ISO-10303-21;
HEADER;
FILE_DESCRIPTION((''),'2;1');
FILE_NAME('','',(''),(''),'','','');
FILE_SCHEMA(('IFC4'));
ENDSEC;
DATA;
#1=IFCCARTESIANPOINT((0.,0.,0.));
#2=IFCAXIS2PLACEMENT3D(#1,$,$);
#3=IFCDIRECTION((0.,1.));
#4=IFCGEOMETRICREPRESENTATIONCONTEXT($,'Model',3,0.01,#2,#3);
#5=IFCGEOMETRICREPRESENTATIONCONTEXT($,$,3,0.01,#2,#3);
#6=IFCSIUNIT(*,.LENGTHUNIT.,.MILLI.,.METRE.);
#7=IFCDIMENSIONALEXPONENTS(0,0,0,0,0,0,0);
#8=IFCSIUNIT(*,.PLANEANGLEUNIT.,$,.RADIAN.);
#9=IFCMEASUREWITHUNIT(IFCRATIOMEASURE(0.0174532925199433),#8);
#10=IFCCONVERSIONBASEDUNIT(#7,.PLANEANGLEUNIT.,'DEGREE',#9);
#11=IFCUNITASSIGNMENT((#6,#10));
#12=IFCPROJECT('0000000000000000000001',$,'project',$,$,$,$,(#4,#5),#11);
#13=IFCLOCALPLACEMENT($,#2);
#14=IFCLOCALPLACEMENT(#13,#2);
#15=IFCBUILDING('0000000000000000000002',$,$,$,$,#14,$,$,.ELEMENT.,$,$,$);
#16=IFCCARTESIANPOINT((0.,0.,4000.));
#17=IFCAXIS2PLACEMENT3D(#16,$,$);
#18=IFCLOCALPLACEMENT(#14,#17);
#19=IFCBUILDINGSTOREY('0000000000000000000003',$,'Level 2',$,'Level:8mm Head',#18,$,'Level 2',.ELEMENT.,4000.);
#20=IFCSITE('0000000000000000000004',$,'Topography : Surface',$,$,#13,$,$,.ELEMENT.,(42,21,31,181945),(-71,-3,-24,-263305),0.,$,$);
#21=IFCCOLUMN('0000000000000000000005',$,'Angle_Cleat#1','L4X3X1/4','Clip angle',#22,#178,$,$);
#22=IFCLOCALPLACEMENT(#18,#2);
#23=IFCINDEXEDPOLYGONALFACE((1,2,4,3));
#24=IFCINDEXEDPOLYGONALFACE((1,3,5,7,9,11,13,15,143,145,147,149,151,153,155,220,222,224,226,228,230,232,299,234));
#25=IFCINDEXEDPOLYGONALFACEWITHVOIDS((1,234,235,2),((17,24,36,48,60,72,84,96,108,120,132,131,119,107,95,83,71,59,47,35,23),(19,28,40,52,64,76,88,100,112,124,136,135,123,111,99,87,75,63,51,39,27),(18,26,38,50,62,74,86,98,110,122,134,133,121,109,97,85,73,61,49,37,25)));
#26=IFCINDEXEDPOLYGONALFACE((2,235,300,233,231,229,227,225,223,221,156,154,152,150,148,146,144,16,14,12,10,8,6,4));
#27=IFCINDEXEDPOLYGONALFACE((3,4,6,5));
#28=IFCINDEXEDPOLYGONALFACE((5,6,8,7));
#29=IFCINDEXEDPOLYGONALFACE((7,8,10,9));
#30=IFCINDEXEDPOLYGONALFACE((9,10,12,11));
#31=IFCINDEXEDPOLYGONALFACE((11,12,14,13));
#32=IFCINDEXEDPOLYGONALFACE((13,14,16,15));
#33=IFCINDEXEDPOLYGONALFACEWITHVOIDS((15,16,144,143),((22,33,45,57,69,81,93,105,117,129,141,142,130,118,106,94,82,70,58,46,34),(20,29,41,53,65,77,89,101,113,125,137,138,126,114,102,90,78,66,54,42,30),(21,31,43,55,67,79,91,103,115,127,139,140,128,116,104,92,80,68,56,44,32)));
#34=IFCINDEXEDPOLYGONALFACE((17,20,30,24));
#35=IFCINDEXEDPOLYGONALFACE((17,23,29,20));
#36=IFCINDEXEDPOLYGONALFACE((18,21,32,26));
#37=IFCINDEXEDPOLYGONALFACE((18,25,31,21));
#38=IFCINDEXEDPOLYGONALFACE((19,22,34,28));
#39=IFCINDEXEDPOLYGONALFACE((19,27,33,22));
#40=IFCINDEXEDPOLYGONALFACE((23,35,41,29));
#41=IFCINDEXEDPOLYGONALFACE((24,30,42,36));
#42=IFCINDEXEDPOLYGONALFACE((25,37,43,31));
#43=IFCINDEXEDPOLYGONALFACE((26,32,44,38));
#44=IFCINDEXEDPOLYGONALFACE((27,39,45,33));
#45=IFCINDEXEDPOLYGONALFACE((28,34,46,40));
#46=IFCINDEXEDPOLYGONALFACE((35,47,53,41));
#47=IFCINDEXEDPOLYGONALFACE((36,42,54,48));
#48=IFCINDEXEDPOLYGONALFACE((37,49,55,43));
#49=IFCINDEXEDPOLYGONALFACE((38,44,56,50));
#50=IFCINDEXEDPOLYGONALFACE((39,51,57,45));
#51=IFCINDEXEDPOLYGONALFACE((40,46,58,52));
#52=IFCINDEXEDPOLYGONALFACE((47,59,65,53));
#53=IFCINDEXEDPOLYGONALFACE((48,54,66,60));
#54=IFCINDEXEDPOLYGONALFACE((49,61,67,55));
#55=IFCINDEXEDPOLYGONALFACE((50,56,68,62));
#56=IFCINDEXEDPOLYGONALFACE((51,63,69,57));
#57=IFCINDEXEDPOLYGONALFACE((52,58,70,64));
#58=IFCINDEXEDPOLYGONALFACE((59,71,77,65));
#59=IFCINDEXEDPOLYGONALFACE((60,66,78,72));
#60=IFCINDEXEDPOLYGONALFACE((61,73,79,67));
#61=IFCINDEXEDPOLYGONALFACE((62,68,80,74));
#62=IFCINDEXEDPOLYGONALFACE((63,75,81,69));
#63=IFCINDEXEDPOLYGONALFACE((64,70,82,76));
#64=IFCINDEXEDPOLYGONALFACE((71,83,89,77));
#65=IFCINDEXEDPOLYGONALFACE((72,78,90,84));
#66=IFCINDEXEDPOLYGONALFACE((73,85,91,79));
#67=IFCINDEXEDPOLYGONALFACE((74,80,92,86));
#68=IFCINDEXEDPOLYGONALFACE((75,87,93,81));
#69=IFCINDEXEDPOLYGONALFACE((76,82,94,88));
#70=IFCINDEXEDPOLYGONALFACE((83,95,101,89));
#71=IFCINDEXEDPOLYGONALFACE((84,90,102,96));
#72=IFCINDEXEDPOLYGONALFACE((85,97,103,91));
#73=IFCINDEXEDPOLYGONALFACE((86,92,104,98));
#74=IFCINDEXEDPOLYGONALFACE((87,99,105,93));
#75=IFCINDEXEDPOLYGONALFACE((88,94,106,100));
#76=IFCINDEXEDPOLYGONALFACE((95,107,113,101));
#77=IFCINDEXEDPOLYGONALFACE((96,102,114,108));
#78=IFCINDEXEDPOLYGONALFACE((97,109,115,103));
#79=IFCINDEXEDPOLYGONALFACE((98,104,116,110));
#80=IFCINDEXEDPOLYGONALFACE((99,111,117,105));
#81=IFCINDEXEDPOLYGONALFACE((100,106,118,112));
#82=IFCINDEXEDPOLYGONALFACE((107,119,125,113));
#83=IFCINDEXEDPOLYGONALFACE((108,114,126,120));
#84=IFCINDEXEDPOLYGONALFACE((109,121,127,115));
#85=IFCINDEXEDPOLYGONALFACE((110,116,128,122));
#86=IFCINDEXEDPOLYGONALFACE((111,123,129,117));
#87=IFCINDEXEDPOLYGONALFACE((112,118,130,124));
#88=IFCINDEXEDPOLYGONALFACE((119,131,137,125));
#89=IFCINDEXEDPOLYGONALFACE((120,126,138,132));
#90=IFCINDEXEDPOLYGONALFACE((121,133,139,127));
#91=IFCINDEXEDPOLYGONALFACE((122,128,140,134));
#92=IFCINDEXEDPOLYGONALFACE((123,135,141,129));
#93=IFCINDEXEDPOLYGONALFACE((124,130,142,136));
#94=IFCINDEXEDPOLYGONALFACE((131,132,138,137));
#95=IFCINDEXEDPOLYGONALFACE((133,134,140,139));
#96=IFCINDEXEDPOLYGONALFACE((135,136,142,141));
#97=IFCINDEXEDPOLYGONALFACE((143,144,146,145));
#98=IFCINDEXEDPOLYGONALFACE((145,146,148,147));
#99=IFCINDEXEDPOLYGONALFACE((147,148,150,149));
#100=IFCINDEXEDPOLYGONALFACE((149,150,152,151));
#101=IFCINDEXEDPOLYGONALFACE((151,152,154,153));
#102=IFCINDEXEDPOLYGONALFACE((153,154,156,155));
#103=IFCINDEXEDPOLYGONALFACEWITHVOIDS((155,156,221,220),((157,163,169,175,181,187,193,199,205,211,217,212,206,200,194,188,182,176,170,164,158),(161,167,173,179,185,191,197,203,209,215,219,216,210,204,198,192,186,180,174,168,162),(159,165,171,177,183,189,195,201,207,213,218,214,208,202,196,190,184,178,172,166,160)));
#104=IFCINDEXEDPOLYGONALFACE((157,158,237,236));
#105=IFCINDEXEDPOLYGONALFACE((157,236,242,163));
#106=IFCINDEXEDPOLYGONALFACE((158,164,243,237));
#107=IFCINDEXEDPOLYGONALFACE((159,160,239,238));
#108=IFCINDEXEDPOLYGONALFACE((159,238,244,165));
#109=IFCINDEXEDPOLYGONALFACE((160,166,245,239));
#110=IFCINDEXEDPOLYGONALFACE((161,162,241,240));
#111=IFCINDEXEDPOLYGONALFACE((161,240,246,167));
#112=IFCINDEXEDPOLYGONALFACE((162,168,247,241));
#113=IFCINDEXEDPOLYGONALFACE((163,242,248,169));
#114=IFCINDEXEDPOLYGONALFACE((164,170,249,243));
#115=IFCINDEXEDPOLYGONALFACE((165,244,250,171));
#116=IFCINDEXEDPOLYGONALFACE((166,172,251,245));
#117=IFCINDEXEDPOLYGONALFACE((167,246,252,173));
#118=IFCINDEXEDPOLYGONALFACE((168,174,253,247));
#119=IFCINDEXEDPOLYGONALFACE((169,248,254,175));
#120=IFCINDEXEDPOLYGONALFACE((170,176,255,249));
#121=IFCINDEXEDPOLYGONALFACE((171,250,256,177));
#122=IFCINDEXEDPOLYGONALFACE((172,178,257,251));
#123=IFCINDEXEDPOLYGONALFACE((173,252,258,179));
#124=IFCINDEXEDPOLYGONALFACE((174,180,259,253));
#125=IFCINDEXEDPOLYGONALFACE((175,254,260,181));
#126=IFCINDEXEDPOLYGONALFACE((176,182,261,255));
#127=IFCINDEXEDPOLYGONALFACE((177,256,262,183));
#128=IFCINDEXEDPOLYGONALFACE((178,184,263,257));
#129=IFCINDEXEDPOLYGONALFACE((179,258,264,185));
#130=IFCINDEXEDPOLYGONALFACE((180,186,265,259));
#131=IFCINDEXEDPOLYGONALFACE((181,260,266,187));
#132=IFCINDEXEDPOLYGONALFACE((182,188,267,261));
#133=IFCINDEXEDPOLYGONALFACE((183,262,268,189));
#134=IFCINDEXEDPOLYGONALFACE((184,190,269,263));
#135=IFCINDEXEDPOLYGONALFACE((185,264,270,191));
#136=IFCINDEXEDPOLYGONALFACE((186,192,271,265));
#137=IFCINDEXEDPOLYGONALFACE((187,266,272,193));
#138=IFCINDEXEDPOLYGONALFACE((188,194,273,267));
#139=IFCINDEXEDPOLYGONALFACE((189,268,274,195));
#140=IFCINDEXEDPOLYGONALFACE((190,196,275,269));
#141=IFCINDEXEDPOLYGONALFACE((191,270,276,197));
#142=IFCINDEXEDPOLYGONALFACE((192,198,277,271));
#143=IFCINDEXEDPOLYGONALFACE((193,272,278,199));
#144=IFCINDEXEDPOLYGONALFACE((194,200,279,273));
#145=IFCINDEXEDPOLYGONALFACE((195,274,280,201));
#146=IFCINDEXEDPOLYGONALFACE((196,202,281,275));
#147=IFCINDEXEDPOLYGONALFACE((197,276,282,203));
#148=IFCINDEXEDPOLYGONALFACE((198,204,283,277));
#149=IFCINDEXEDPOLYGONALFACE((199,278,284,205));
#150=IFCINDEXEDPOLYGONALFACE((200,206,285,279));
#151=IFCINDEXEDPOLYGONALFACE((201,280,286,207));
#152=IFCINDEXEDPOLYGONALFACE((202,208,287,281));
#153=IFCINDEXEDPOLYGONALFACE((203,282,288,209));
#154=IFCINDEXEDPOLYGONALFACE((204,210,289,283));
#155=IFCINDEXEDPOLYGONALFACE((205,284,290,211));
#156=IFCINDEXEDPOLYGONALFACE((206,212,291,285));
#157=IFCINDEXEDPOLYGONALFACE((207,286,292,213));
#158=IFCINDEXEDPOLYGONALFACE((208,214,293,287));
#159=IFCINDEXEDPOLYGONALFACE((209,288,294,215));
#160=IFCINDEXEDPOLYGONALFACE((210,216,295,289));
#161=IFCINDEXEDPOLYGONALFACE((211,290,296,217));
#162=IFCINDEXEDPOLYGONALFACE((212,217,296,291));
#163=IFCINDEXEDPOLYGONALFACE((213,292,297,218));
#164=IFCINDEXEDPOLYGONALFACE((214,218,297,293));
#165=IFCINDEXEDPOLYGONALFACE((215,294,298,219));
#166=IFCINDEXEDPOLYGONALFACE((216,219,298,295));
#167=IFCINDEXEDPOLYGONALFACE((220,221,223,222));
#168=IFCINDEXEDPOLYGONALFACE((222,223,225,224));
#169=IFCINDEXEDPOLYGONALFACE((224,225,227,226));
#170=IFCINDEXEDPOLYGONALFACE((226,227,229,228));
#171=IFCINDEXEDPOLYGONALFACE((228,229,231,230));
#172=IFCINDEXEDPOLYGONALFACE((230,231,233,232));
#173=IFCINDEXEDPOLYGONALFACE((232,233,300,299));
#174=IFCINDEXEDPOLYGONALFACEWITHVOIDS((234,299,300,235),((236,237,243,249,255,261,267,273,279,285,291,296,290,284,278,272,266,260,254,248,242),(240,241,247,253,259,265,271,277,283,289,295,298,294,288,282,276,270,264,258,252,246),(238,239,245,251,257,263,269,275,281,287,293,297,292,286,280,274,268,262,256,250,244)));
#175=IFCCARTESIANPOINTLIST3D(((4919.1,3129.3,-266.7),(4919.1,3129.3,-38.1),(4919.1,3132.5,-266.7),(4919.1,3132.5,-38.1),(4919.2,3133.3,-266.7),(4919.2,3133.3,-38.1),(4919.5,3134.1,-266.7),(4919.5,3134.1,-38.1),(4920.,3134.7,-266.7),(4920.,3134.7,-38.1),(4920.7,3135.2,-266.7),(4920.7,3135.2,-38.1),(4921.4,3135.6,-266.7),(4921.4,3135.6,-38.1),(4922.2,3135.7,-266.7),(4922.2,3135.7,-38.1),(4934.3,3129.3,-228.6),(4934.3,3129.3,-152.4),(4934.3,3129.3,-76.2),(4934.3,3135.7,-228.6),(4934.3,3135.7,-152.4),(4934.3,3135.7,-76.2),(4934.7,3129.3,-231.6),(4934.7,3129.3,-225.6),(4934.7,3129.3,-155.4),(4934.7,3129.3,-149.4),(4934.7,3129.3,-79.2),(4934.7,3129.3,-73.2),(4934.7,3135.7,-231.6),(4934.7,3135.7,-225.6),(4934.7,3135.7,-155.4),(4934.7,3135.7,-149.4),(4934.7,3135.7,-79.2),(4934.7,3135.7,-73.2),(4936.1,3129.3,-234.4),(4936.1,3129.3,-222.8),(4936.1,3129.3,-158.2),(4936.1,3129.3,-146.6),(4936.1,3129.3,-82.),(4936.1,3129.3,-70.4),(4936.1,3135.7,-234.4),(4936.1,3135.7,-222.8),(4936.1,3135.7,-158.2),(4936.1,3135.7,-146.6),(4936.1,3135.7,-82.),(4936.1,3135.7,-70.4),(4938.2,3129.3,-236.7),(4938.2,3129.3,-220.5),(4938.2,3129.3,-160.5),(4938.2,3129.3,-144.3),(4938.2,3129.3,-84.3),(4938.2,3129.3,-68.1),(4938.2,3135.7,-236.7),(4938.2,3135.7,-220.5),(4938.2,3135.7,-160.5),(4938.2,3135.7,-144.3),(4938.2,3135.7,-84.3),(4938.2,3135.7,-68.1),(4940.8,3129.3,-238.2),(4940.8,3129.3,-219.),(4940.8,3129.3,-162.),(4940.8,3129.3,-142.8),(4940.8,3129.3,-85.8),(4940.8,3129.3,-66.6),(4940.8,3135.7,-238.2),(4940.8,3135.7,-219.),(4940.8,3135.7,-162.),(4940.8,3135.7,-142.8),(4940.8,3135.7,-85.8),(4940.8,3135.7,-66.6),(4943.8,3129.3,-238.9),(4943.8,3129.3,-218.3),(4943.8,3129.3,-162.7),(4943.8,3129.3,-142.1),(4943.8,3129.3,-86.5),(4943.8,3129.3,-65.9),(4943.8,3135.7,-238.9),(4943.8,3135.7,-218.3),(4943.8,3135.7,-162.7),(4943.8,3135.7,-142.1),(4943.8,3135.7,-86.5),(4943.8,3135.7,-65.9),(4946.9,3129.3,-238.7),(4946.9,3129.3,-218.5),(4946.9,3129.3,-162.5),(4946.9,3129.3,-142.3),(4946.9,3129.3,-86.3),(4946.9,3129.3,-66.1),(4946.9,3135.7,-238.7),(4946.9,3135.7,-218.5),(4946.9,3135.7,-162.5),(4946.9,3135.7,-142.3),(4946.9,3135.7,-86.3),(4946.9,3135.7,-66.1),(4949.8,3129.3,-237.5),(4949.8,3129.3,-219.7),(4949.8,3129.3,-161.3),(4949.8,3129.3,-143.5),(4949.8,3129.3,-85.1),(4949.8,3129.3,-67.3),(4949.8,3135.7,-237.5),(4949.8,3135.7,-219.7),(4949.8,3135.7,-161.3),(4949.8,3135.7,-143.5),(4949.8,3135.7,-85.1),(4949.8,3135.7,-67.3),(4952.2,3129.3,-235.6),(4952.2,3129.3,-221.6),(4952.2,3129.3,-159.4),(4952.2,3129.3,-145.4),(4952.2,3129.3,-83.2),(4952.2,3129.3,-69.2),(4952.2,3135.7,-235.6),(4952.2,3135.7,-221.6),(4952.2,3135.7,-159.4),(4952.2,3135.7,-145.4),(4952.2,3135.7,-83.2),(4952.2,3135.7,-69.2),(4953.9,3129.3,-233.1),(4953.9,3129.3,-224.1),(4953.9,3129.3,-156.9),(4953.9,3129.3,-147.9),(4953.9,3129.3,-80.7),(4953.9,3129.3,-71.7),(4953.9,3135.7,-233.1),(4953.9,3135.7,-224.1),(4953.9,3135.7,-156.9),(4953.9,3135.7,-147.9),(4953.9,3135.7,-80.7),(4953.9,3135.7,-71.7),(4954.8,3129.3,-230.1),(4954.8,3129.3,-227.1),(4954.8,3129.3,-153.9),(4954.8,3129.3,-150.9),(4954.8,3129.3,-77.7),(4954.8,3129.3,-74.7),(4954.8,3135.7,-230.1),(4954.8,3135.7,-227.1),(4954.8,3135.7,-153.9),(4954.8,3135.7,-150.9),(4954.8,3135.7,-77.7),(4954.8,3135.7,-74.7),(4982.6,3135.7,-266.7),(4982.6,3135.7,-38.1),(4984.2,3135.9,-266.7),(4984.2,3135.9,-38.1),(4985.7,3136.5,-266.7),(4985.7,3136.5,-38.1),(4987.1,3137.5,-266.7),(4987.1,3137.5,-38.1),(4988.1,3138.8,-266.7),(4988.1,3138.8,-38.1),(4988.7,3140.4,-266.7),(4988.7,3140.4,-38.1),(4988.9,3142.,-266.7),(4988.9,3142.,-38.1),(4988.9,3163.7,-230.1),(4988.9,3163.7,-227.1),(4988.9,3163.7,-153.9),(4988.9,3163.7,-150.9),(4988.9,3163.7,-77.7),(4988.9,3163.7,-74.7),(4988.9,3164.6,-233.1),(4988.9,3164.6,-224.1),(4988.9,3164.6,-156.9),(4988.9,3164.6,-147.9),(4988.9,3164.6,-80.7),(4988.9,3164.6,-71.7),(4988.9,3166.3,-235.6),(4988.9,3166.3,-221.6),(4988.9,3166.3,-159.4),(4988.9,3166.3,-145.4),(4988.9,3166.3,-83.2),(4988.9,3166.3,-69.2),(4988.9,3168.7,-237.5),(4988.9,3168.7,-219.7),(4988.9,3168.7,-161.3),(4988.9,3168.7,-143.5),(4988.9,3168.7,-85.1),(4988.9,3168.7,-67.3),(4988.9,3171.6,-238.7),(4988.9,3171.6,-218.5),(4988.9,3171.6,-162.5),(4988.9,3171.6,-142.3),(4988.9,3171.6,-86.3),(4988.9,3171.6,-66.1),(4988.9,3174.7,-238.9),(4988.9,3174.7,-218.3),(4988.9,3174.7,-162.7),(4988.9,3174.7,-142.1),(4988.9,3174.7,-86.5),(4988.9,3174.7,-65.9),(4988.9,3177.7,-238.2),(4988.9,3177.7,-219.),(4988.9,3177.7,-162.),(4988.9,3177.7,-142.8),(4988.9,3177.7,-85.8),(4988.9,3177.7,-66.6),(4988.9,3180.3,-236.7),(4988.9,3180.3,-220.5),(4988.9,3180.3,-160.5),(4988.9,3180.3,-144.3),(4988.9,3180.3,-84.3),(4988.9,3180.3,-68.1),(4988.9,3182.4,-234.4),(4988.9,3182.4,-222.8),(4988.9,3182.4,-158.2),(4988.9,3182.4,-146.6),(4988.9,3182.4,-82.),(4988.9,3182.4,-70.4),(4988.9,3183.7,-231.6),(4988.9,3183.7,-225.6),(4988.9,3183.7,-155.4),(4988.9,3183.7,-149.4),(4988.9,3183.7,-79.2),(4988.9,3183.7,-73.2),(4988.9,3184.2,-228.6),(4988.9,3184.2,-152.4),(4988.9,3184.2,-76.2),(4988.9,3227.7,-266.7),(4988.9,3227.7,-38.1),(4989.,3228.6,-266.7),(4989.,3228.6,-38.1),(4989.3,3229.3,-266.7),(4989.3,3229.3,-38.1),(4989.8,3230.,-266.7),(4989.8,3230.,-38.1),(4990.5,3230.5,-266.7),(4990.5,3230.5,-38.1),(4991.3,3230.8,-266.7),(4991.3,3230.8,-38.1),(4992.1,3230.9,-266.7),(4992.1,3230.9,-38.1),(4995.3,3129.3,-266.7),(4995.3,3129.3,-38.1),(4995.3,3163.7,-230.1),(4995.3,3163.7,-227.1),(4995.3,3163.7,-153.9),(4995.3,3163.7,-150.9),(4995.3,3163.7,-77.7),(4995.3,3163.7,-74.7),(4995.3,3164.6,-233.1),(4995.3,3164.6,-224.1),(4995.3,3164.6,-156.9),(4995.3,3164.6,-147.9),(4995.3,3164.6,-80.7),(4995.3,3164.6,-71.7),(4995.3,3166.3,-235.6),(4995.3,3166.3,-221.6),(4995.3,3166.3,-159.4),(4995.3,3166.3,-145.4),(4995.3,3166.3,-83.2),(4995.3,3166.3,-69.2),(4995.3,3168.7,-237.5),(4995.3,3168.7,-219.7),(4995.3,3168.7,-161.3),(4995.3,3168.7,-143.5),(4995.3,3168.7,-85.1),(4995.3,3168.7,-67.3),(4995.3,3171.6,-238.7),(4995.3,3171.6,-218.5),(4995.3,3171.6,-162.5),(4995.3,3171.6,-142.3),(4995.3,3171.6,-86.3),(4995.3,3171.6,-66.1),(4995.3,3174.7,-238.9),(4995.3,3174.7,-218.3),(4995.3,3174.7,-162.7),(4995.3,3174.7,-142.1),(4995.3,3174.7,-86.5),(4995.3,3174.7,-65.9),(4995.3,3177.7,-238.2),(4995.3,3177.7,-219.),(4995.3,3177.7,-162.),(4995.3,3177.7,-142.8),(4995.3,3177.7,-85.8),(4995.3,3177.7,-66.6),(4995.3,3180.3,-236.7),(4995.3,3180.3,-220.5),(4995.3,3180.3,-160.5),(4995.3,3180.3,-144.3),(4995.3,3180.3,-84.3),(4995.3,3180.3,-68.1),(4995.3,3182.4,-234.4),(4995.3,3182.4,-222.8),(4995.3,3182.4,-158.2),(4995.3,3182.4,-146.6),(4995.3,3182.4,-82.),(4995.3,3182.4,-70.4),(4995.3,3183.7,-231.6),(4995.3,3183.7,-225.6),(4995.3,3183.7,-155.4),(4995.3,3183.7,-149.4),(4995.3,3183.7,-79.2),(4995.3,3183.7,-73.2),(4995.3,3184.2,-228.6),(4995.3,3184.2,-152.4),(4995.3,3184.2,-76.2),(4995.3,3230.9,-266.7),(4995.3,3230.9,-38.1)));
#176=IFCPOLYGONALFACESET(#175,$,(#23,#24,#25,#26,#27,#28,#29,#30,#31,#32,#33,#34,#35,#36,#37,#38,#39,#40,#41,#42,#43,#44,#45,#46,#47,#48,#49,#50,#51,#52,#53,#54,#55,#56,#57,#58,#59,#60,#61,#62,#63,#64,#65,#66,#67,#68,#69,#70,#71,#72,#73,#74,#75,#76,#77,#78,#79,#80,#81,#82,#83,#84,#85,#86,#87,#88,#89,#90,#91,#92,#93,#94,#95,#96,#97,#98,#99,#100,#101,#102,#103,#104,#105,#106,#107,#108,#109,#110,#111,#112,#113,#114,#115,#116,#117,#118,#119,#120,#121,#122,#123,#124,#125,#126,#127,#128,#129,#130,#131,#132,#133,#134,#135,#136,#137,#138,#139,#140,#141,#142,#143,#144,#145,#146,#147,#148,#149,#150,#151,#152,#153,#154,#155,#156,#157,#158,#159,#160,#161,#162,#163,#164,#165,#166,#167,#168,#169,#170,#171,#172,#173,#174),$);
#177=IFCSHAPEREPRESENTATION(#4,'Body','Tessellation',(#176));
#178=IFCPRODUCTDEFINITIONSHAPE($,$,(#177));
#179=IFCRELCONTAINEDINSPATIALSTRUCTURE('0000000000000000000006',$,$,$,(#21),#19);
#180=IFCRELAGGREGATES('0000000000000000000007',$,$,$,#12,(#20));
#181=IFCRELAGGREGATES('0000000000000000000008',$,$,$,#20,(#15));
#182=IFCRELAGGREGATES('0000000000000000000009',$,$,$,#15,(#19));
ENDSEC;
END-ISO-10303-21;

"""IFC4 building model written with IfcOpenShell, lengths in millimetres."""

from ifc_helpers import new_model, entity, si_unit, converted_unit, direction, frame, frame_2d, origin, origin_2d_with_axis, place, context, project, spatial, circle, l_section, extrude, element, save


model = new_model("IFC4")

# Units and contexts
model_context = context("Model", 3, precision=0.01, world=origin(), true_north=direction((0.0, 1.0)))
context_of_model = context(None, 3, precision=0.01, world=origin(), true_north=direction((0.0, 1.0)))
ifc_project = project(units=[si_unit("LENGTHUNIT", "METRE", prefix="MILLI"), converted_unit("PLANEANGLEUNIT", "DEGREE", entity("IfcRatioMeasure", 0.0174532925199433), si_unit("PLANEANGLEUNIT", "RADIAN"), dimensions=[0, 0, 0, 0, 0, 0, 0])], contexts=[model_context, context_of_model])

# Site, building, storey
site_placement = place(None, origin())
site = spatial("IfcSite", under=ifc_project, at=site_placement, Name="Topography : Surface", CompositionType="ELEMENT", RefLatitude=(42, 21, 31, 181945), RefLongitude=(-71, -3, -24, -263305), RefElevation=0.0)
building_placement = place(site_placement, origin())
building = spatial("IfcBuilding", under=site, at=building_placement, CompositionType="ELEMENT")
storey_placement = place(building_placement, frame((0.0, 0.0, 4000.0)))
storey = spatial("IfcBuildingStorey", under=building, at=storey_placement, Name="Level 2", ObjectType="Level:8mm Head", LongName="Level 2", CompositionType="ELEMENT", Elevation=4000.0)

# Column, openings
column_1_placement = place(storey_placement, frame((4977.0, 3160.4, -266.7), z_axis=(0.0, 0.0, -1.0), x_axis=(-1.0, 0.0, 0.0)))
column_1 = element("IfcColumn", 1, at=column_1_placement, inside=storey, Name="Angle_Cleat#1", Description="L4X3X1/4", ObjectType="Clip angle", context=model_context, shape_type="SweptSolid", body=[
    extrude(l_section(Depth=101.6, Width=76.2, Thickness=6.3, FilletRadius=6.3, EdgeRadius=3.2, at=frame_2d((19.8, 19.7))), origin(), (0.0, 0.0, -1.0), 228.6),
])
opening_1_placement = place(column_1_placement, frame((32.4, -31.5, -114.3), z_axis=(0.0, 1.0, 0.0), x_axis=(1.0, 0.0, 0.0)))
element("IfcOpeningElement", 2, at=opening_1_placement, cuts=column_1, ObjectType="Opening", context=model_context, shape_type="SweptSolid", body=[
    extrude(circle(Radius=10.3, at=origin_2d_with_axis()), origin(), (0.0, 0.0, 1.0), 7.3),
])
opening_2_placement = place(column_1_placement, frame((32.4, -31.5, -114.3), z_axis=(0.0, 1.0, 0.0), x_axis=(1.0, 0.0, 0.0)))
element("IfcOpeningElement", 3, at=opening_2_placement, cuts=column_1, ObjectType="Opening", context=model_context, shape_type="SweptSolid", body=[
    extrude(circle(Radius=10.3, at=frame_2d((0.0, 76.2), x_axis=(1.0, 0.0))), origin(), (0.0, 0.0, 1.0), 7.3),
])
opening_3_placement = place(column_1_placement, frame((32.4, -31.5, -114.3), z_axis=(0.0, 1.0, 0.0), x_axis=(1.0, 0.0, 0.0)))
element("IfcOpeningElement", 4, at=opening_3_placement, cuts=column_1, ObjectType="Opening", context=model_context, shape_type="SweptSolid", body=[
    extrude(circle(Radius=10.3, at=frame_2d((0.0, -76.2), x_axis=(1.0, 0.0))), origin(), (0.0, 0.0, 1.0), 7.3),
])
opening_4_placement = place(column_1_placement, frame((-18.9, 13.5, -114.3), z_axis=(1.0, 0.0, 0.0), x_axis=(0.0, 1.0, 0.0)))
element("IfcOpeningElement", 5, at=opening_4_placement, cuts=column_1, ObjectType="Opening", context=model_context, shape_type="SweptSolid", body=[
    extrude(circle(Radius=10.3, at=origin_2d_with_axis()), origin(), (0.0, 0.0, 1.0), 7.3),
])
opening_5_placement = place(column_1_placement, frame((-18.9, 13.5, -114.3), z_axis=(1.0, 0.0, 0.0), x_axis=(0.0, 1.0, 0.0)))
element("IfcOpeningElement", 6, at=opening_5_placement, cuts=column_1, ObjectType="Opening", context=model_context, shape_type="SweptSolid", body=[
    extrude(circle(Radius=10.3, at=frame_2d((0.0, 76.2), x_axis=(1.0, 0.0))), origin(), (0.0, 0.0, 1.0), 7.3),
])
opening_6_placement = place(column_1_placement, frame((-18.9, 13.5, -114.3), z_axis=(1.0, 0.0, 0.0), x_axis=(0.0, 1.0, 0.0)))
element("IfcOpeningElement", 7, at=opening_6_placement, cuts=column_1, ObjectType="Opening", context=model_context, shape_type="SweptSolid", body=[
    extrude(circle(Radius=10.3, at=frame_2d((0.0, -76.2), x_axis=(1.0, 0.0))), origin(), (0.0, 0.0, 1.0), 7.3),
])

save(model, "model.ifc")
